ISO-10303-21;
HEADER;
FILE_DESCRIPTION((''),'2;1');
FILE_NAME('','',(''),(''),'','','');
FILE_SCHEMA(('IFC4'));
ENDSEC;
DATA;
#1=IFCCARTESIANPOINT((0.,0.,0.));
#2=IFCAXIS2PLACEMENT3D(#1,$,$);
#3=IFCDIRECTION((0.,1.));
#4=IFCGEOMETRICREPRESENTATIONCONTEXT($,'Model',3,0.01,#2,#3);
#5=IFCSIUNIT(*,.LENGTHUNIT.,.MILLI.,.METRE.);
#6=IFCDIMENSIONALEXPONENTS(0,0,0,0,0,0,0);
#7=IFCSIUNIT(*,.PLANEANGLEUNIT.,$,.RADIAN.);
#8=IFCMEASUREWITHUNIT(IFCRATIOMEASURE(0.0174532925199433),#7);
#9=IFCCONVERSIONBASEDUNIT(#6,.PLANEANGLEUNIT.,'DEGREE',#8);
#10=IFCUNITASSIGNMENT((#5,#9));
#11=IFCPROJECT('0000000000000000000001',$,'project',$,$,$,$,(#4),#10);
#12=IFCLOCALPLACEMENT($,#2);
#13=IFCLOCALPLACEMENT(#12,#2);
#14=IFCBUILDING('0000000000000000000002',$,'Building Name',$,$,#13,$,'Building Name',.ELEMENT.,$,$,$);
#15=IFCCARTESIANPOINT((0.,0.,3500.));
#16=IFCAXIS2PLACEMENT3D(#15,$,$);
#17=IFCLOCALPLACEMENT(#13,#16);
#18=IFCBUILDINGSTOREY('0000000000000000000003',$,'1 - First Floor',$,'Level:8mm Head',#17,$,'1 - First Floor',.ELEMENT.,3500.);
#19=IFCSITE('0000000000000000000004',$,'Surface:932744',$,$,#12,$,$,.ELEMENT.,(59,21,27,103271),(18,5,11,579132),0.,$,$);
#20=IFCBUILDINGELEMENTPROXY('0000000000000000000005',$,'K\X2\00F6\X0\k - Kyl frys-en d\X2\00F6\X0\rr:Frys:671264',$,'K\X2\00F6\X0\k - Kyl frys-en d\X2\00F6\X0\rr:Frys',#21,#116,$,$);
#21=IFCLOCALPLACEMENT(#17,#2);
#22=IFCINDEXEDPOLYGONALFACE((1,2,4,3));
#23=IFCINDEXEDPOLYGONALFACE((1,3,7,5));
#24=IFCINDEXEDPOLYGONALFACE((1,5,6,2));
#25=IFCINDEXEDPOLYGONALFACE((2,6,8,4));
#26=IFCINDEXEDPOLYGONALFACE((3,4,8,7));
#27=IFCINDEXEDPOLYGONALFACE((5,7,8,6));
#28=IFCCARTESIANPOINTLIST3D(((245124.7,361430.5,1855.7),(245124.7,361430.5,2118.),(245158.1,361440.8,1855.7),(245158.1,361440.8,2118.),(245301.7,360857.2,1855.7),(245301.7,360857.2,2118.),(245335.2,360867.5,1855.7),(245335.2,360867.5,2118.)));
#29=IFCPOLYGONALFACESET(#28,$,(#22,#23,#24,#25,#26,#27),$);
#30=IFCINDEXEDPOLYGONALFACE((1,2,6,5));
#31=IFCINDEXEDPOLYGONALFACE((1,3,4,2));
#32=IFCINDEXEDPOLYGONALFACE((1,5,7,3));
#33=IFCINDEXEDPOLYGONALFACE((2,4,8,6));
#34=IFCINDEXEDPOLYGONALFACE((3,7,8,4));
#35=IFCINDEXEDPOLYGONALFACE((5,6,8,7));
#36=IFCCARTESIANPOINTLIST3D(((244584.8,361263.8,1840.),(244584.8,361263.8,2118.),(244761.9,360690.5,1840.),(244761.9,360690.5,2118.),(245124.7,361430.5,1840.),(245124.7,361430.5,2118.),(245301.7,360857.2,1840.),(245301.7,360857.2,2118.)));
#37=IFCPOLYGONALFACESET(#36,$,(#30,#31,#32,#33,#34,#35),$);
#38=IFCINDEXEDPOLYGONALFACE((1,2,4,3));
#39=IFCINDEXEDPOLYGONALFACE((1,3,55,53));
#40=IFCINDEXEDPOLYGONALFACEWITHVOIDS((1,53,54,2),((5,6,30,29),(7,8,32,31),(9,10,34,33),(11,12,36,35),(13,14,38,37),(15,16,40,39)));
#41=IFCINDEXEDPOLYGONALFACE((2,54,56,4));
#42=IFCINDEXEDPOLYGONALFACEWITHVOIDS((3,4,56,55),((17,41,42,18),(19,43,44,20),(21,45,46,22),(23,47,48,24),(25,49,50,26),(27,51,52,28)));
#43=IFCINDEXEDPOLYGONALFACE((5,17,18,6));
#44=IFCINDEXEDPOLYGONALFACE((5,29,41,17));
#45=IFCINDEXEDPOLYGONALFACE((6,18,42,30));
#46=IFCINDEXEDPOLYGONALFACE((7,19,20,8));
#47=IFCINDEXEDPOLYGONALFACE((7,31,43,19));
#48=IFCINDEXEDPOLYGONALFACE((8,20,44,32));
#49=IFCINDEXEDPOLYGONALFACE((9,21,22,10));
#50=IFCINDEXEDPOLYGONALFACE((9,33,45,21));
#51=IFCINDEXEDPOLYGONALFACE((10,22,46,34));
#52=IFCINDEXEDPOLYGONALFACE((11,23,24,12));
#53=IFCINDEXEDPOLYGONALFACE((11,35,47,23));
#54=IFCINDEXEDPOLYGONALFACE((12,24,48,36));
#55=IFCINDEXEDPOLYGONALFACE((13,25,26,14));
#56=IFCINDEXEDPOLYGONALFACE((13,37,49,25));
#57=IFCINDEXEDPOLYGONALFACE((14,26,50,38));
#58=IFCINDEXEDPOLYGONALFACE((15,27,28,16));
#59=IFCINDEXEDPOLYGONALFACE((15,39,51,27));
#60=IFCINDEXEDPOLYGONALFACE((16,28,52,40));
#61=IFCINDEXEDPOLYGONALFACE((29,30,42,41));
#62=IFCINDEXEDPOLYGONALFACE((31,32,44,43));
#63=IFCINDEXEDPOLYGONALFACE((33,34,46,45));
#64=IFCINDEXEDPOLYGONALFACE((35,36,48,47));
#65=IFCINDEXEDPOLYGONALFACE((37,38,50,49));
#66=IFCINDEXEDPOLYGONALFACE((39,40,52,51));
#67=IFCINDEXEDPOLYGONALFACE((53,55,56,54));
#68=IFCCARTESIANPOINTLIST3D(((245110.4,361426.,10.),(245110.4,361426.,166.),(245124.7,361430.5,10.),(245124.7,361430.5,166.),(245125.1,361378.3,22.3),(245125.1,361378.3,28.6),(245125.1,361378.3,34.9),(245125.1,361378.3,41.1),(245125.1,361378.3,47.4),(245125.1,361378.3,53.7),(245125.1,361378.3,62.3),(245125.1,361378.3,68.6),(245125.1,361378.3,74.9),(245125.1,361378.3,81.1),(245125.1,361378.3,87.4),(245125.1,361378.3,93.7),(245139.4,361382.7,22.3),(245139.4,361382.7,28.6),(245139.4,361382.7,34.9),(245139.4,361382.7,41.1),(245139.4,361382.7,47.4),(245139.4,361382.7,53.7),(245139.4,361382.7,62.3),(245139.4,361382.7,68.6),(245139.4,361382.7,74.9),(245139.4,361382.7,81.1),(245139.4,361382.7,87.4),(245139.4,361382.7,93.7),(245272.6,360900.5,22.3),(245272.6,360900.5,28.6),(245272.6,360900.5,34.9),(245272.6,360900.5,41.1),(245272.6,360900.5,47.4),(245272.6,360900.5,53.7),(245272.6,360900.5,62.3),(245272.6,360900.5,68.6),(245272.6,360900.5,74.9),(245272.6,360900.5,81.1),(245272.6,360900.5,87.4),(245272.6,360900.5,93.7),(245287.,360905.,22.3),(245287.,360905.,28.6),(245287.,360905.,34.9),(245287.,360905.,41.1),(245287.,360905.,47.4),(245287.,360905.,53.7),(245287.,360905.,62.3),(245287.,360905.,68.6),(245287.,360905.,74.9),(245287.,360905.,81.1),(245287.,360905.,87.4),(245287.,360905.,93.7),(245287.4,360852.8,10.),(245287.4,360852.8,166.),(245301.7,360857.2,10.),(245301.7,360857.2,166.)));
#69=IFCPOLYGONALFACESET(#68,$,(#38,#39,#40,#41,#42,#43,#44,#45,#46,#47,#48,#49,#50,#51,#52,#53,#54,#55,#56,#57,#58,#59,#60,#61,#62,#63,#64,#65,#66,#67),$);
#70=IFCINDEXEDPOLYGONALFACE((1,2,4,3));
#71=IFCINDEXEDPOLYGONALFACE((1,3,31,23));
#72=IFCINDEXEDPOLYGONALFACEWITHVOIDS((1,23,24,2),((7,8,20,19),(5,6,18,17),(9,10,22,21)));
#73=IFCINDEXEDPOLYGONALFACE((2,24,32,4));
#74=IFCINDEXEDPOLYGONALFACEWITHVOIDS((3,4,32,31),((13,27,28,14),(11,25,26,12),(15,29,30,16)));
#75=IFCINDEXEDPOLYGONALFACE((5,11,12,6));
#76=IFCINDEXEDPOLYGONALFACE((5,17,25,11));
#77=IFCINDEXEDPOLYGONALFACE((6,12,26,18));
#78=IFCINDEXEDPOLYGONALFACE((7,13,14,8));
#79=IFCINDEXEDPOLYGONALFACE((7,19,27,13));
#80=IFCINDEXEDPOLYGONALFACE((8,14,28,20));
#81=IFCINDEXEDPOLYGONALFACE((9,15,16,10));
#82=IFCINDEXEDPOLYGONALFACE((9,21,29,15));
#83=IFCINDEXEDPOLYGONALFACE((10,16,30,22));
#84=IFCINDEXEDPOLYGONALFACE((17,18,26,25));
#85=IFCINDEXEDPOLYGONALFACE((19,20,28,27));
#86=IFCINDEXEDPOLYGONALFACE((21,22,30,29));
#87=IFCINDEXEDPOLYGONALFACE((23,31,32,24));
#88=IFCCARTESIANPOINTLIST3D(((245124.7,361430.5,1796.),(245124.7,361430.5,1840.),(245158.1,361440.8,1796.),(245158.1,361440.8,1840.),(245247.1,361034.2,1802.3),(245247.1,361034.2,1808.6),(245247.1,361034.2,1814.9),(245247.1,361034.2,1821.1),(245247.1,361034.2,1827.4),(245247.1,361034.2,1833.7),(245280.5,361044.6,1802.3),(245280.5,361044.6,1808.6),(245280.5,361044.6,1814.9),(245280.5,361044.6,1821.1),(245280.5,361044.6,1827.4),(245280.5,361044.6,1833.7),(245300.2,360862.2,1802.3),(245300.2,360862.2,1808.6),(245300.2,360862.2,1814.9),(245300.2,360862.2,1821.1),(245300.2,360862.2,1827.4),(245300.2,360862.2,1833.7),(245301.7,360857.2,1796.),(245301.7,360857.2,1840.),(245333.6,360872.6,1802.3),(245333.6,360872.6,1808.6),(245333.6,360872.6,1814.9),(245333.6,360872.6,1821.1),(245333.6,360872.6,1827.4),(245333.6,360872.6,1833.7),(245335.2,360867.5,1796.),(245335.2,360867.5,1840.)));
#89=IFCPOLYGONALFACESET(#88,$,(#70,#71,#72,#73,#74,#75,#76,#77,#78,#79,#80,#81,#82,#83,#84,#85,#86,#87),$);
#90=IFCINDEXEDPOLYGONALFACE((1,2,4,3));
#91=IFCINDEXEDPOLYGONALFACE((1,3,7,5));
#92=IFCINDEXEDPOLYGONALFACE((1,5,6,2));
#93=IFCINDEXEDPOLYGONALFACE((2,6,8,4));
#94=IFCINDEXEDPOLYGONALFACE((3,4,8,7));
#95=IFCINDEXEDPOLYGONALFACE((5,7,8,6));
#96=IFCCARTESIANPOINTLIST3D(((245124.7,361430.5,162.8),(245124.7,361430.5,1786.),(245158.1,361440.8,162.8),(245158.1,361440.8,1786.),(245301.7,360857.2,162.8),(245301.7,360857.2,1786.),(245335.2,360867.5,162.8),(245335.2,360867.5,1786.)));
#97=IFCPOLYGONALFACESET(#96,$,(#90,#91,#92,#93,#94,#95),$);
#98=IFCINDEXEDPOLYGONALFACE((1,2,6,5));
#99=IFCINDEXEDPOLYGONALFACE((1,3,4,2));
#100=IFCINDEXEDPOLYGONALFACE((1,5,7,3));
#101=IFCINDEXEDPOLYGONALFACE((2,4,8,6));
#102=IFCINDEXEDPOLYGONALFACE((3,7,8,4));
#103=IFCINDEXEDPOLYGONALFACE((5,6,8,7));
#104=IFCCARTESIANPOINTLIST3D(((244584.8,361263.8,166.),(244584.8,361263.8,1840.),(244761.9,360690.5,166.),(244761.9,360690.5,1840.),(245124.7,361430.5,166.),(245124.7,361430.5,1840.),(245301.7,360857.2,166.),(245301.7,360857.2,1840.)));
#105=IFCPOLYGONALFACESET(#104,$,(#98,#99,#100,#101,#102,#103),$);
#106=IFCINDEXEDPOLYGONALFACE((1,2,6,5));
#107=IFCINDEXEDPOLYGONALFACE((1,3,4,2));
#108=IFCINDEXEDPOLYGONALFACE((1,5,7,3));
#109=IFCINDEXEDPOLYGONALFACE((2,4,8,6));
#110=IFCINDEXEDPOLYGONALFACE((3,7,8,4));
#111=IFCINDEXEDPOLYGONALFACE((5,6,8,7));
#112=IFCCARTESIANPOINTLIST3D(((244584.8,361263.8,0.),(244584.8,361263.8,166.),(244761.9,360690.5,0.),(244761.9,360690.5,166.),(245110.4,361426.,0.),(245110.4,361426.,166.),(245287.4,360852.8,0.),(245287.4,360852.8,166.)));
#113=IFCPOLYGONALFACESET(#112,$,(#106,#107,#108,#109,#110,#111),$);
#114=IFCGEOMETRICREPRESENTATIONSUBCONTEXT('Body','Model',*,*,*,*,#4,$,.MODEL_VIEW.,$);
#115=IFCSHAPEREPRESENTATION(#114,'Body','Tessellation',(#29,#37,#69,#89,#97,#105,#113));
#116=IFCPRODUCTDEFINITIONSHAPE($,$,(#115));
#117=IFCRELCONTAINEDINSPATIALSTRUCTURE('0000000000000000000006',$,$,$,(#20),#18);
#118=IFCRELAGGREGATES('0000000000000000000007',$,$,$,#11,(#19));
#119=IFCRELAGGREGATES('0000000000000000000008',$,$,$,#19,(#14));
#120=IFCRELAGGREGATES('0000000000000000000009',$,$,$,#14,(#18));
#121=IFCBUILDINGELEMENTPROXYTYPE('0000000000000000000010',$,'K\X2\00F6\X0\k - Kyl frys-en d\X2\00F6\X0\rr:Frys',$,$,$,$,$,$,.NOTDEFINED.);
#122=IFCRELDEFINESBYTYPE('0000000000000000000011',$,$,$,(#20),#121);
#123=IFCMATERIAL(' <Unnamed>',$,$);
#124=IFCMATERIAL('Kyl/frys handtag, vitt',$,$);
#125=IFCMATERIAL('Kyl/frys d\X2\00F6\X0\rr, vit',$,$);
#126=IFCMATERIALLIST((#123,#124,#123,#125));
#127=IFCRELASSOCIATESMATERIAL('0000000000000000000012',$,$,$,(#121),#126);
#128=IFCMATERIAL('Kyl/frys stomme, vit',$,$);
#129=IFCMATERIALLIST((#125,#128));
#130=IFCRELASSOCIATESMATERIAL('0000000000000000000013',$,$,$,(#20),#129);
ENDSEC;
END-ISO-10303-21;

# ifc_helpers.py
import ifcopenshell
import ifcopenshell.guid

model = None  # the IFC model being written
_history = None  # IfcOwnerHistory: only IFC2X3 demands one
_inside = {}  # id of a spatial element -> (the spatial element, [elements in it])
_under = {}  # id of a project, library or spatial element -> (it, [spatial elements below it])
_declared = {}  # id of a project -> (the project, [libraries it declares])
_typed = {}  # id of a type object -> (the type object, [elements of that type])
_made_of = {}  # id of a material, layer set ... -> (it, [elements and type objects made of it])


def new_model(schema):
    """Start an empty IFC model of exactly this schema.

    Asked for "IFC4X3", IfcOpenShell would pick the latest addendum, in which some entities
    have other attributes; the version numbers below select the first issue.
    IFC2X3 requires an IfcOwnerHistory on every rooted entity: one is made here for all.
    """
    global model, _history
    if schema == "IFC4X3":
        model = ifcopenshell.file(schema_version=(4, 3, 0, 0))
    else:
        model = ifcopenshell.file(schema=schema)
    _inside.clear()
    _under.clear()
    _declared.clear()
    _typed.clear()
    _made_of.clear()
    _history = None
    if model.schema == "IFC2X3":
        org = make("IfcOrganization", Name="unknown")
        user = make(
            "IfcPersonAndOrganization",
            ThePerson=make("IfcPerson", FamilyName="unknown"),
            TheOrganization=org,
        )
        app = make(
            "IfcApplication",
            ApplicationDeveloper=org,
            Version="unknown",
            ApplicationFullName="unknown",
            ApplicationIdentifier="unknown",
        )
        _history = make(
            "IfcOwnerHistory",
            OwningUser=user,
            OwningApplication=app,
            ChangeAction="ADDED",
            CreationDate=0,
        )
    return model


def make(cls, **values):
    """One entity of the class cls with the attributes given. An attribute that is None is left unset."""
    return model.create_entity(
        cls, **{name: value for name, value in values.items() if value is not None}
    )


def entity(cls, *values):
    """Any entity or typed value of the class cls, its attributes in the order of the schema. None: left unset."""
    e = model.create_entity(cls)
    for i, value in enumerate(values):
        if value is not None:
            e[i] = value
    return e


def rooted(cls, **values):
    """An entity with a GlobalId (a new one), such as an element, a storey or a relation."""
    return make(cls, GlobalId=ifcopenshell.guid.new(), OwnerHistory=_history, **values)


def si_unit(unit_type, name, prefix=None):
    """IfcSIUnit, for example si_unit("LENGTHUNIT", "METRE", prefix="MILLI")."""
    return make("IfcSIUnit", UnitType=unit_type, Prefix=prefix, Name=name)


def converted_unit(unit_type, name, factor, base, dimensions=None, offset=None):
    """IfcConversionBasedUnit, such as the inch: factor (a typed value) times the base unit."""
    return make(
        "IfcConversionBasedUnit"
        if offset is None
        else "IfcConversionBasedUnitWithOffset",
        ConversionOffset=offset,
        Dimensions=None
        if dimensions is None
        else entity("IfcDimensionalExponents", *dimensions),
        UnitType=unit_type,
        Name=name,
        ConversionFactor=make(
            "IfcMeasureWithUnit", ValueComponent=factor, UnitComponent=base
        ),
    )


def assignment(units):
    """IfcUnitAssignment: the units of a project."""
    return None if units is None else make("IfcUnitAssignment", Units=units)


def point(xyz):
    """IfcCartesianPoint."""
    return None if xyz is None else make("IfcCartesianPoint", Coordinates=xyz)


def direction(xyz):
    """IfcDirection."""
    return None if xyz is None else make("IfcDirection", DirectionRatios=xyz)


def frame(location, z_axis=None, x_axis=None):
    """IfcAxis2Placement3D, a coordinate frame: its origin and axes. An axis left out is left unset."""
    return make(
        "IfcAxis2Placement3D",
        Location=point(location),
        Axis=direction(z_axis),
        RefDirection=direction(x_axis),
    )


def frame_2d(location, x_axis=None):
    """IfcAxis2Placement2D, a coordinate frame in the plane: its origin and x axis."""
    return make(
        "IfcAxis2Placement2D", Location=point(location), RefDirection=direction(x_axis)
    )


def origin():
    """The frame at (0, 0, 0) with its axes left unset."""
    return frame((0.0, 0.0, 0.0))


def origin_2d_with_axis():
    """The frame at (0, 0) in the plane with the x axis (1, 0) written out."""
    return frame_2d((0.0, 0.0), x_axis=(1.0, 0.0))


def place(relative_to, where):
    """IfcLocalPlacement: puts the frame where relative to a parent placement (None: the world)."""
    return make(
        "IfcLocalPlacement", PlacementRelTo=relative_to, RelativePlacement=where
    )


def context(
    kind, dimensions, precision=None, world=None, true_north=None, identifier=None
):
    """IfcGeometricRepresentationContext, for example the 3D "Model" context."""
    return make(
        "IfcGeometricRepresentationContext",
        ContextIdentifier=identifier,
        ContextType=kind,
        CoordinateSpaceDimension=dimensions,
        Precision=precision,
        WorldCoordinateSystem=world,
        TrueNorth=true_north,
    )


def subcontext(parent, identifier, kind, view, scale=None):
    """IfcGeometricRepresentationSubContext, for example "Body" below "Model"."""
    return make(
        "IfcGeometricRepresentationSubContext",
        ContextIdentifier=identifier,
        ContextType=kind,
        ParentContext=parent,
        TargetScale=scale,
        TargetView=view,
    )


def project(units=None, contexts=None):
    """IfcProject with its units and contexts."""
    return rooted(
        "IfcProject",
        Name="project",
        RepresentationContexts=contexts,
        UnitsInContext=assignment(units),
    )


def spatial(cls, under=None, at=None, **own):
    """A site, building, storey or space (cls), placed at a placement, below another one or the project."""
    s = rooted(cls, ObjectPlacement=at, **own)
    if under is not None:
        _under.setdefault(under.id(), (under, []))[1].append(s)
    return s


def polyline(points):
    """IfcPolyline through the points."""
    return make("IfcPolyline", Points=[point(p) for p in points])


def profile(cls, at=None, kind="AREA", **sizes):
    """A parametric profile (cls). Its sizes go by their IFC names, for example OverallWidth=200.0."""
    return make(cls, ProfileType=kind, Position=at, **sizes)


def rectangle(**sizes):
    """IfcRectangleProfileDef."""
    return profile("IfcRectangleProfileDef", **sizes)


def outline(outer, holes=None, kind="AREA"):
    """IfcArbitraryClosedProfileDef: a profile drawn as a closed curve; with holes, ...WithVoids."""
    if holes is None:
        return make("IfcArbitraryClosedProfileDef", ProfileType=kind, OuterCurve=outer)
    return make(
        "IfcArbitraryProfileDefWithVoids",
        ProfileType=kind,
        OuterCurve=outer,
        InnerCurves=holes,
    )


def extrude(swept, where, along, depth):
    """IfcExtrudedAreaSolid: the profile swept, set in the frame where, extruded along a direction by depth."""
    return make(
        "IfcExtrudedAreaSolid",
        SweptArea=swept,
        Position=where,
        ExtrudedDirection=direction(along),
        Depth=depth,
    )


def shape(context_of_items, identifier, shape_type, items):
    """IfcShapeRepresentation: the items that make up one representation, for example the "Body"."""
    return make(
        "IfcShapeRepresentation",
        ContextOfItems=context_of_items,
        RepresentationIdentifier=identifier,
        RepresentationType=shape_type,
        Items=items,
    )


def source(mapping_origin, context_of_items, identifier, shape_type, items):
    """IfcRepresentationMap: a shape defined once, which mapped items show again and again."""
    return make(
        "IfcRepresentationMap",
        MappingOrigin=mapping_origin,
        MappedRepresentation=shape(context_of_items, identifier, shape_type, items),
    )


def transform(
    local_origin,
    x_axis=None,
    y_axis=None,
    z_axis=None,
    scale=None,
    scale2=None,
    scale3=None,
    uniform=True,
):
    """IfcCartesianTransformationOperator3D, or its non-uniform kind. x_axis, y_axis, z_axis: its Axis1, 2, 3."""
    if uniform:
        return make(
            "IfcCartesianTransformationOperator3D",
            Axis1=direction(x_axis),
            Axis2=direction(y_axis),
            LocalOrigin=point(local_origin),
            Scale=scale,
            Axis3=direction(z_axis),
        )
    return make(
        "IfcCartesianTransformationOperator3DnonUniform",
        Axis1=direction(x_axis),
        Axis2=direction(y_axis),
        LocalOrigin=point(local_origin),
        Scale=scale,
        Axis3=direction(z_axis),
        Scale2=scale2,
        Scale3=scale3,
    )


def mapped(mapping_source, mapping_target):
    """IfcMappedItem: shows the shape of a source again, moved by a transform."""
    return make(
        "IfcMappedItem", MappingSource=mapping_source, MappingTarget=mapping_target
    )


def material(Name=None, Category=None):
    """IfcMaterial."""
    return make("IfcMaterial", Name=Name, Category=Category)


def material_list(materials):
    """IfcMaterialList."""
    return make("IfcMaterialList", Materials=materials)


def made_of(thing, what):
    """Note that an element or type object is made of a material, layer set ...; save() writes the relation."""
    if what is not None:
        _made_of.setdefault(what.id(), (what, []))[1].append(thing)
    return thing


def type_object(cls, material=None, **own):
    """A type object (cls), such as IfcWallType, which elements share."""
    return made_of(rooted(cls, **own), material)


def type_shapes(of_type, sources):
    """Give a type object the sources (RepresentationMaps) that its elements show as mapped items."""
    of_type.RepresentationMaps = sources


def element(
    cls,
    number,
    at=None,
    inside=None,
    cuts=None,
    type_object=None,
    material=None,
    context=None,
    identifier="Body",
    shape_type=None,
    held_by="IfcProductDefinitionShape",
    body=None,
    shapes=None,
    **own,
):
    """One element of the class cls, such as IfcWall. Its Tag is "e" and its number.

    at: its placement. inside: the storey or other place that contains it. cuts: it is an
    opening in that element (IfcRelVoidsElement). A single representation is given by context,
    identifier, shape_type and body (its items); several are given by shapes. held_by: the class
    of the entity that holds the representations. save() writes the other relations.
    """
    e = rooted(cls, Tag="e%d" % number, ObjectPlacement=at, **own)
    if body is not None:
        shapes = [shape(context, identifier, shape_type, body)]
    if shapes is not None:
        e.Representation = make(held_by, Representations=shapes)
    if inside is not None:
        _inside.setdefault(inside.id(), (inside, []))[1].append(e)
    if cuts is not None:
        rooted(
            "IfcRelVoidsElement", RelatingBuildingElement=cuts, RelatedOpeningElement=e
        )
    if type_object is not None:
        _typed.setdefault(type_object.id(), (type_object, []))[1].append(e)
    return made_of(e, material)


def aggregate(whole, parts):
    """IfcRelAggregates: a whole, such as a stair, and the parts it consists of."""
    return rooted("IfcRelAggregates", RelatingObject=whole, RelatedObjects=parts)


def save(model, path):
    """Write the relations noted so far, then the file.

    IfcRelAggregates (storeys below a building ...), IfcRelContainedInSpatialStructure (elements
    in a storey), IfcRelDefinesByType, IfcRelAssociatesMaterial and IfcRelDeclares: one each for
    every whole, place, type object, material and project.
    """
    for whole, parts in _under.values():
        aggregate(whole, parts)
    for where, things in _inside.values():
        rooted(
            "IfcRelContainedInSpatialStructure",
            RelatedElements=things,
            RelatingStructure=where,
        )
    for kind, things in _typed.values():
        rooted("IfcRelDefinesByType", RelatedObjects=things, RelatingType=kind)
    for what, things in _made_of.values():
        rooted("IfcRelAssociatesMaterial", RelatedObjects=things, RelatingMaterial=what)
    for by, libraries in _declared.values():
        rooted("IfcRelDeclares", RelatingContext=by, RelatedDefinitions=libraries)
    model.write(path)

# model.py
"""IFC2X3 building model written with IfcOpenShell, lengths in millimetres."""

from ifc_helpers import new_model, entity, si_unit, converted_unit, direction, frame, frame_2d, origin, origin_2d_with_axis, place, context, subcontext, project, spatial, polyline, rectangle, outline, extrude, source, transform, mapped, material, material_list, type_object, type_shapes, element, save


model = new_model("IFC2X3")

# Units and contexts
model_context = context("Model", 3, precision=0.01, world=origin(), true_north=direction((0.0, 1.0)))
body_context = subcontext(model_context, "Body", "Model", "MODEL_VIEW")
ifc_project = project(units=[si_unit("LENGTHUNIT", "METRE", prefix="MILLI"), converted_unit("PLANEANGLEUNIT", "DEGREE", entity("IfcRatioMeasure", 0.0174532925199433), si_unit("PLANEANGLEUNIT", "RADIAN"), dimensions=[0, 0, 0, 0, 0, 0, 0])], contexts=[model_context])

# Site, building, storey
site_placement = place(None, origin())
site = spatial("IfcSite", under=ifc_project, at=site_placement, Name="Surface:932744", CompositionType="ELEMENT", RefLatitude=(59, 21, 27, 103271), RefLongitude=(18, 5, 11, 579132), RefElevation=0.0)
building_placement = place(site_placement, origin())
building = spatial("IfcBuilding", under=site, at=building_placement, Name="Building Name", LongName="Building Name", CompositionType="ELEMENT")
storey_placement = place(building_placement, frame((0.0, 0.0, 3500.0)))
storey = spatial("IfcBuildingStorey", under=building, at=storey_placement, Name="1 - First Floor", ObjectType="Level:8mm Head", LongName="1 - First Floor", CompositionType="ELEMENT", Elevation=3500.0)

# Shared definitions
ifc_material_1 = material(Name=" <Unnamed>")

# Building element proxy
ifc_material_2 = material(Name="Kyl/frys dörr, vit")
ifc_material_3 = material(Name="Kyl/frys stomme, vit")
ifc_material_list_1 = material_list([ifc_material_2, ifc_material_3])
ifc_material_4 = material(Name="Kyl/frys handtag, vitt")
ifc_material_list_2 = material_list([ifc_material_1, ifc_material_4, ifc_material_1, ifc_material_2])
building_element_proxy_type_1 = type_object("IfcBuildingElementProxyType", Name="Kök - Kyl frys-en dörr:Frys", PredefinedType="NOTDEFINED", material=ifc_material_list_2)
shared_shape_1 = source(origin(), body_context, "Body", "SweptSolid", [
    extrude(rectangle(XDim=35.0, YDim=600.0, at=frame_2d((0.0, 0.0), x_axis=(1.0, 0.0))), frame((-254.6, 169.3, 1855.7), z_axis=(0.0, 0.0, 1.0), x_axis=(0.0, -1.0, 0.0)), (0.0, 0.0, 1.0), 262.3),
    extrude(rectangle(XDim=600.0, YDim=565.0, at=origin_2d_with_axis()), frame((-254.6, 469.3, 1840.0), z_axis=(0.0, 0.0, 1.0), x_axis=(-1.0, 0.0, 0.0)), (0.0, 0.0, 1.0), 278.0),
    extrude(outline(polyline([(-300.0, -78.0), (300.0, -78.0), (300.0, 78.0), (-300.0, 78.0), (-300.0, -78.0)]), holes=[polyline([(-250.0, 5.7), (250.0, 5.7), (250.0, -0.6), (-250.0, -0.6), (-250.0, 5.7)]), polyline([(-250.0, -6.9), (250.0, -6.9), (250.0, -13.1), (-250.0, -13.1), (-250.0, -6.9)]), polyline([(-250.0, -19.4), (250.0, -19.4), (250.0, -25.7), (-250.0, -25.7), (-250.0, -19.4)]), polyline([(-250.0, -34.3), (250.0, -34.3), (250.0, -40.6), (-250.0, -40.6), (-250.0, -34.3)]), polyline([(-250.0, -46.9), (250.0, -46.9), (250.0, -53.1), (-250.0, -53.1), (-250.0, -46.9)]), polyline([(-250.0, -59.4), (250.0, -59.4), (250.0, -65.7), (-250.0, -65.7), (-250.0, -59.4)])]), frame((-254.6, 186.8, 88.0), z_axis=(0.0, 1.0, 0.0), x_axis=(-1.0, 0.0, 0.0)), (0.0, 0.0, 1.0), 15.0),
    extrude(outline(polyline([(-300.0, -22.0), (300.0, -22.0), (300.0, 22.0), (-300.0, 22.0), (-300.0, -22.0)]), holes=[polyline([(114.7, 15.7), (294.7, 15.7), (294.7, 9.4), (114.7, 9.4), (114.7, 15.7)]), polyline([(114.7, 3.1), (294.7, 3.1), (294.7, -3.1), (114.7, -3.1), (114.7, 3.1)]), polyline([(114.7, -9.4), (294.7, -9.4), (294.7, -15.7), (114.7, -15.7), (114.7, -9.4)])]), frame((-254.6, 151.8, 1818.0), z_axis=(0.0, 1.0, 0.0), x_axis=(-1.0, 0.0, 0.0)), (0.0, 0.0, 1.0), 35.0),
    extrude(rectangle(XDim=35.0, YDim=600.0, at=frame_2d((0.0, 0.0), x_axis=(1.0, 0.0))), frame((-254.6, 169.3, 162.8), z_axis=(0.0, 0.0, 1.0), x_axis=(0.0, -1.0, 0.0)), (0.0, 0.0, 1.0), 1623.2),
    extrude(rectangle(XDim=600.0, YDim=565.0, at=frame_2d((0.0, 0.0), x_axis=(1.0, 0.0))), frame((-254.6, 469.3, 166.0), z_axis=(0.0, 0.0, 1.0), x_axis=(-1.0, 0.0, 0.0)), (0.0, 0.0, 1.0), 1674.0),
    extrude(rectangle(XDim=600.0, YDim=550.0, at=frame_2d((0.0, 0.0), x_axis=(1.0, 0.0))), frame((-254.6, 476.8, 0.0), z_axis=(0.0, 0.0, 1.0), x_axis=(-1.0, 0.0, 0.0)), (0.0, 0.0, 1.0), 166.0),
])
type_shapes(building_element_proxy_type_1, [shared_shape_1])
proxy_1_placement = place(storey_placement, frame((245316.6, 361442.2, 0.0), z_axis=(0.0, 0.0, 1.0), x_axis=(-0.29508, 0.955473, 0.0)))
element("IfcBuildingElementProxy", 1, at=proxy_1_placement, inside=storey, type_object=building_element_proxy_type_1, material=ifc_material_list_1, Name="Kök - Kyl frys-en dörr:Frys:671264", ObjectType="Kök - Kyl frys-en dörr:Frys", context=body_context, shape_type="MappedRepresentation", body=[
    mapped(shared_shape_1, transform((0.0, 0.0, 0.0), scale=1.0)),
])

save(model, "model.ifc")
